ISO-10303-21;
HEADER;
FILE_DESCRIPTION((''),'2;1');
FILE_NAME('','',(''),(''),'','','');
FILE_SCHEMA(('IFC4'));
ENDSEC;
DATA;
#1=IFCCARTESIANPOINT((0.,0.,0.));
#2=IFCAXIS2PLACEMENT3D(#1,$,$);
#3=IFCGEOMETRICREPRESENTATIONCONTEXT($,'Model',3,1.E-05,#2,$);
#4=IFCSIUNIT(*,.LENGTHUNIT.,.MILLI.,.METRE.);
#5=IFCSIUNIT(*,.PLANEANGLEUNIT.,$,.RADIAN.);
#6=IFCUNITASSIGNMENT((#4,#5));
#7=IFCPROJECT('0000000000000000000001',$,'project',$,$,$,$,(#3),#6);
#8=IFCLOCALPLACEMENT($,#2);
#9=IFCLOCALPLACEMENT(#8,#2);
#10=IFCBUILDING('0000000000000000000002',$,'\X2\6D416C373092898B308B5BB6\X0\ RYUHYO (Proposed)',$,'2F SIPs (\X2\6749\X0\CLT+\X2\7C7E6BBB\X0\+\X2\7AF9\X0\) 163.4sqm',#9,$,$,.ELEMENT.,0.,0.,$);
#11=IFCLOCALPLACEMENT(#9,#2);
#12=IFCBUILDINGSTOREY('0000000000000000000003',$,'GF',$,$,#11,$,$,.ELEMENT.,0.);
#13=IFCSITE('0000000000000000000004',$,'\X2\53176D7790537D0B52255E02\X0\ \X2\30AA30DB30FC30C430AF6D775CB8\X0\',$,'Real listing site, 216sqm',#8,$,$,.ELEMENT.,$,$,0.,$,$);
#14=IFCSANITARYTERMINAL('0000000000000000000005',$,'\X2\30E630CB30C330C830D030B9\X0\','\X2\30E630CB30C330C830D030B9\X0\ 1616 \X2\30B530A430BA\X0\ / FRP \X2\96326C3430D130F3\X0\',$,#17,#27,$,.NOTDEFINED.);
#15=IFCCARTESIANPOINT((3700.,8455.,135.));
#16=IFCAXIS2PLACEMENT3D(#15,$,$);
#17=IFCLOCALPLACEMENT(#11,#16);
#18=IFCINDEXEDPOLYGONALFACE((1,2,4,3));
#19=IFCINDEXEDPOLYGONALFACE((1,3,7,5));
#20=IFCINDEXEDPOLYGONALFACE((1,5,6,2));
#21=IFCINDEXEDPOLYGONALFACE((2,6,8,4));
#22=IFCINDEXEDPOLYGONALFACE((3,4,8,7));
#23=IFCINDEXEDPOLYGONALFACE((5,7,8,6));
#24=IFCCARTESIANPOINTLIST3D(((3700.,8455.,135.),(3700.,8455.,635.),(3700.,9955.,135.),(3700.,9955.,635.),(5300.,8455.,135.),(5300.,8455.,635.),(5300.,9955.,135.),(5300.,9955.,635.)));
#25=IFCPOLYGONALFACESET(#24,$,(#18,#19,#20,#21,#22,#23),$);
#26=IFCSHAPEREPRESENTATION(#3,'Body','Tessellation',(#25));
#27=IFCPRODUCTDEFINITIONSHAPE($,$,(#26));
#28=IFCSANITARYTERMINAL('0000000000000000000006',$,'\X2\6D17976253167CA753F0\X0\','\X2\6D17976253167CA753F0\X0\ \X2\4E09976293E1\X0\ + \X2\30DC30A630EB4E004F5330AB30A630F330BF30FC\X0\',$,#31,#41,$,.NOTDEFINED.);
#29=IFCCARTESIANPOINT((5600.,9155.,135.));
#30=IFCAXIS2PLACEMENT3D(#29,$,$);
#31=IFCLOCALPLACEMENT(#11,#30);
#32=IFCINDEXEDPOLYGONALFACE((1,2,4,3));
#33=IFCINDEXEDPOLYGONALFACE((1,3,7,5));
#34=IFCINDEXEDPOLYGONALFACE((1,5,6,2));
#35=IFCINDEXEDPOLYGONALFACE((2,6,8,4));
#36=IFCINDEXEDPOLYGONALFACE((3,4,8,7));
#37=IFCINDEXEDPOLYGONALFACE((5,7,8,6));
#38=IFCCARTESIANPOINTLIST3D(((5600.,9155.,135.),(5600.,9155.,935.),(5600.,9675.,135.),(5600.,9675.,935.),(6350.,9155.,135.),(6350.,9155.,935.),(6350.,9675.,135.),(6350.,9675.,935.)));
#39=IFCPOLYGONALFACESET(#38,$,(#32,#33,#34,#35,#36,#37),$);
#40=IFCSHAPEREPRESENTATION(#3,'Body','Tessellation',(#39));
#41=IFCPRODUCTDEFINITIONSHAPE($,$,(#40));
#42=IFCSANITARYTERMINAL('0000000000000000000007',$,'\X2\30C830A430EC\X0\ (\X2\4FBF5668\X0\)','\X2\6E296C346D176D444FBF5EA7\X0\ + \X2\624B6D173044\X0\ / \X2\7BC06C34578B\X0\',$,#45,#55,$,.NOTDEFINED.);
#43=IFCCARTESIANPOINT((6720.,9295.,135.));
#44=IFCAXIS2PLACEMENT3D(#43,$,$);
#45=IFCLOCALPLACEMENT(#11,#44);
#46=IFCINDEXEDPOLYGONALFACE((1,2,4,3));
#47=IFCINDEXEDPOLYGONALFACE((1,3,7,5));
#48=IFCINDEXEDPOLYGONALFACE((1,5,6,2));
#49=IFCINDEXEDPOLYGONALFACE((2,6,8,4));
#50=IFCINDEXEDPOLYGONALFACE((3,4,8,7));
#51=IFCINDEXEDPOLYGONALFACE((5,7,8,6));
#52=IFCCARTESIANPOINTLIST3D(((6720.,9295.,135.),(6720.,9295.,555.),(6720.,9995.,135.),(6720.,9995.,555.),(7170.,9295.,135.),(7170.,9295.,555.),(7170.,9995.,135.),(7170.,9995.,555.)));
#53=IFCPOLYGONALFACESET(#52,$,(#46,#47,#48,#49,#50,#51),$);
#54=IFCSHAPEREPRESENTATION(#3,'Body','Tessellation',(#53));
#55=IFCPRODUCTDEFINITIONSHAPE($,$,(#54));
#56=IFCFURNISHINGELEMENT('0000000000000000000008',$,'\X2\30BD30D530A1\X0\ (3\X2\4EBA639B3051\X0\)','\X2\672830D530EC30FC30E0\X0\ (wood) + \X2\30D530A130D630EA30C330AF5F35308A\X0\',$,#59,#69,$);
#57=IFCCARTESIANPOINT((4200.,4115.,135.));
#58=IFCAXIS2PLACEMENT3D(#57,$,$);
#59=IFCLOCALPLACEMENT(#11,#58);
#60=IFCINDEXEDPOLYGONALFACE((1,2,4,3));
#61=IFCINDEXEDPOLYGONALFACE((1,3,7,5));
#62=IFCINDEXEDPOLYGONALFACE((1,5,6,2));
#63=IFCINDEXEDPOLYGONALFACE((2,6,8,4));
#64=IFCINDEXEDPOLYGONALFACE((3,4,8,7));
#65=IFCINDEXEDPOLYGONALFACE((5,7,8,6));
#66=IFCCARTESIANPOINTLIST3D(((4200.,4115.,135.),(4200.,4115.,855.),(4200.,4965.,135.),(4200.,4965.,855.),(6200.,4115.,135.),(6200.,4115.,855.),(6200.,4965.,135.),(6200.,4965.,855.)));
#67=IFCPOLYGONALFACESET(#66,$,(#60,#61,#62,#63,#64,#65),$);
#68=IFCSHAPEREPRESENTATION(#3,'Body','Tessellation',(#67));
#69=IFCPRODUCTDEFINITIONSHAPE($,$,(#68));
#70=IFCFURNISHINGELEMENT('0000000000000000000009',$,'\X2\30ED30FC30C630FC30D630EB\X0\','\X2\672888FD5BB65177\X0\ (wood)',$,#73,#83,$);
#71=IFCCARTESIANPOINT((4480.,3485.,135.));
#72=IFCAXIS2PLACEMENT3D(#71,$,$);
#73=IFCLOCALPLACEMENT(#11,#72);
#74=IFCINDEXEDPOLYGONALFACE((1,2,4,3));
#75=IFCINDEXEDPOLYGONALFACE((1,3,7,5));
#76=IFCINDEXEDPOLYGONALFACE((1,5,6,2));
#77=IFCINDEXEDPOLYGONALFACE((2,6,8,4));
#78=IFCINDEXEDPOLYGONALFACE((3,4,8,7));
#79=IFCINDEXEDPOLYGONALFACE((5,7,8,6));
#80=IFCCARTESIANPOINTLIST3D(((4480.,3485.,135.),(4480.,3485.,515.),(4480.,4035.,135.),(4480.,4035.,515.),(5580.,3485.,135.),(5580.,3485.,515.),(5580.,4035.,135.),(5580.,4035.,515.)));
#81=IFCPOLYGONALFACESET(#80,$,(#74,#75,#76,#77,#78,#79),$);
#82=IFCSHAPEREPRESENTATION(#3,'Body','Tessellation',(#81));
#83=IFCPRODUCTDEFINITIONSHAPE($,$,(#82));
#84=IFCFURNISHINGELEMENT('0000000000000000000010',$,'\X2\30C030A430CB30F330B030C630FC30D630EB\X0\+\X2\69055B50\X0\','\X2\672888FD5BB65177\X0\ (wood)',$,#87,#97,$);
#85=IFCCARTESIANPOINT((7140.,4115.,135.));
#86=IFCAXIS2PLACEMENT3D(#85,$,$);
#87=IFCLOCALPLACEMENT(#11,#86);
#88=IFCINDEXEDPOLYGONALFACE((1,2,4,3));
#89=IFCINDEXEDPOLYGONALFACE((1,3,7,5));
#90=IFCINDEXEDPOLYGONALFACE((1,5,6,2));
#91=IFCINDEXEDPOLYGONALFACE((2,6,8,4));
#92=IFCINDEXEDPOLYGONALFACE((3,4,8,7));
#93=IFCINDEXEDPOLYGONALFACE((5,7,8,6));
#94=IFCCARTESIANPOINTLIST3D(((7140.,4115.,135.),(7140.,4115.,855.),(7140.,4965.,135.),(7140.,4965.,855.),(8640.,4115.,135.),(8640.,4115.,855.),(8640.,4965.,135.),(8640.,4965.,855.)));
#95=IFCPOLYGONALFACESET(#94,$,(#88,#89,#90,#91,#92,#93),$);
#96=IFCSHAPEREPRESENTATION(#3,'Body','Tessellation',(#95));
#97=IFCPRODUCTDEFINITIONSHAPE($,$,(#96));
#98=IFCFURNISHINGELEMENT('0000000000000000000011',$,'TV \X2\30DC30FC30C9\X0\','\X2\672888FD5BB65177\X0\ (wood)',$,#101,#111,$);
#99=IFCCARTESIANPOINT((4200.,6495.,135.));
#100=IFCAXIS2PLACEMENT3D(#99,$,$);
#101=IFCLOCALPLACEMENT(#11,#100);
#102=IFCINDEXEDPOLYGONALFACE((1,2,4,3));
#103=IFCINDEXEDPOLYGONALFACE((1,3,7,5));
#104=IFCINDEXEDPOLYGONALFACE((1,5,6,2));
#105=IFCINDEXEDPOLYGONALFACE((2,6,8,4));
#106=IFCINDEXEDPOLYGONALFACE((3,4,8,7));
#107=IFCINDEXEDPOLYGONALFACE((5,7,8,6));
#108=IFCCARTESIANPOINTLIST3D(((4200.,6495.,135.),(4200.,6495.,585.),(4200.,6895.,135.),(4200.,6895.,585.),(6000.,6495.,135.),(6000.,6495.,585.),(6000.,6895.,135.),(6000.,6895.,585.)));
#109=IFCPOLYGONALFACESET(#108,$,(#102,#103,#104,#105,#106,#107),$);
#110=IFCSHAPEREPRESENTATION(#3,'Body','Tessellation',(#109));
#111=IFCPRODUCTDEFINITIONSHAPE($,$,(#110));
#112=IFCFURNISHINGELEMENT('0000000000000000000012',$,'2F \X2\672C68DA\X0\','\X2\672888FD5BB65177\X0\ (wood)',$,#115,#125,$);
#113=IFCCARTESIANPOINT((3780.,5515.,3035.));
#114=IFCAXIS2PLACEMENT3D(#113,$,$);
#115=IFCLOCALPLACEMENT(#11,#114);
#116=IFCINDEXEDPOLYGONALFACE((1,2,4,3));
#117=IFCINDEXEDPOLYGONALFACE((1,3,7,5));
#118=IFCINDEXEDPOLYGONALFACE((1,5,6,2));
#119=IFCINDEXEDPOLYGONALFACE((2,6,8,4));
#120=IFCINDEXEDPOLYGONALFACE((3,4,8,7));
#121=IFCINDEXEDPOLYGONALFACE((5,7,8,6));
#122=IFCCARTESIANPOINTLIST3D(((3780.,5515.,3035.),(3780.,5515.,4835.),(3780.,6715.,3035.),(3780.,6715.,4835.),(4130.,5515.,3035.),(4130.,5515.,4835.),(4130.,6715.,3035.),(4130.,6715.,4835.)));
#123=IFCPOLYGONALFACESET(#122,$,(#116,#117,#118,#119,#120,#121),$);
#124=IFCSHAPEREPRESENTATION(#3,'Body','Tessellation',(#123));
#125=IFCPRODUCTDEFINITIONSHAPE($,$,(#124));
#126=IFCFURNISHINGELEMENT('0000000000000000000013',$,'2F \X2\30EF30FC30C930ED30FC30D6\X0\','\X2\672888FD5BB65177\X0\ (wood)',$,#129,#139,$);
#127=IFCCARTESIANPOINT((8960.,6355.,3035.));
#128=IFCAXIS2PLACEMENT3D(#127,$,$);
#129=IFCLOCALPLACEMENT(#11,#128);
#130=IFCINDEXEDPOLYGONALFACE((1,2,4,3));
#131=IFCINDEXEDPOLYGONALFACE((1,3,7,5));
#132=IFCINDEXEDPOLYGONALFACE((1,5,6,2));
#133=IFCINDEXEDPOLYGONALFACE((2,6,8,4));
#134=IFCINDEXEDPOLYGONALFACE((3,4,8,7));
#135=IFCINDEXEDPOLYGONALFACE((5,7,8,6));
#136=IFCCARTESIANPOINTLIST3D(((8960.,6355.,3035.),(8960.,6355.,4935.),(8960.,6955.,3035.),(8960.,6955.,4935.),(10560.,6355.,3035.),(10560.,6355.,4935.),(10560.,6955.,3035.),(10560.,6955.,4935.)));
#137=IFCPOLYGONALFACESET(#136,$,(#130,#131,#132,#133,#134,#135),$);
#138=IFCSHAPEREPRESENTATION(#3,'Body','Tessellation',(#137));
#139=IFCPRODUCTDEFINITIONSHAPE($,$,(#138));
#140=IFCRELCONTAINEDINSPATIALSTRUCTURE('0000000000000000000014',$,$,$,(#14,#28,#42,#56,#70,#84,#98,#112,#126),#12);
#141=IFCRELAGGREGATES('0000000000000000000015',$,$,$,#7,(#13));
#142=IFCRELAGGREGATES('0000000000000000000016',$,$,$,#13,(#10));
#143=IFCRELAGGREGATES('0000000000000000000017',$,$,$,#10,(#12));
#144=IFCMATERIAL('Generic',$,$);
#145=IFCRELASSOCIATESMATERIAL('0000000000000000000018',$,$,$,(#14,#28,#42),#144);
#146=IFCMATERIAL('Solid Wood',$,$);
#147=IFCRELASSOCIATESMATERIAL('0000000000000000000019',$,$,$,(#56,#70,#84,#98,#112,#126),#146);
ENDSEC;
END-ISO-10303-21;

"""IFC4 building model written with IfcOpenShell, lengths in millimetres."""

from ifc_helpers import new_model, si_unit, frame, frame_2d, origin, place, context, project, spatial, rectangle, extrude, material, element, save


model = new_model("IFC4")

# Units and contexts
model_context = context("Model", 3, precision=1e-05, world=origin())
ifc_project = project(units=[si_unit("LENGTHUNIT", "METRE", prefix="MILLI"), si_unit("PLANEANGLEUNIT", "RADIAN")], contexts=[model_context])

# Site, building, storey
site_placement = place(None, origin())
site = spatial("IfcSite", under=ifc_project, at=site_placement, Name="北海道紋別市 オホーツク海岸", ObjectType="Real listing site, 216sqm", CompositionType="ELEMENT", RefElevation=0.0)
building_placement = place(site_placement, origin())
building = spatial("IfcBuilding", under=site, at=building_placement, Name="流氷を見る家 RYUHYO (Proposed)", ObjectType="2F SIPs (杉CLT+籾殻+竹) 163.4sqm", CompositionType="ELEMENT", ElevationOfRefHeight=0.0, ElevationOfTerrain=0.0)
storey_placement = place(building_placement, origin())
storey = spatial("IfcBuildingStorey", under=building, at=storey_placement, Name="GF", CompositionType="ELEMENT", Elevation=0.0)

# Shared definitions
ifc_material_1 = material(Name="Generic")

# Shared definitions
ifc_material_2 = material(Name="Solid Wood")

# Sanitary terminals
sanitary_terminal_1_placement = place(storey_placement, frame((3700.0, 8455.0, 135.0)))
element("IfcSanitaryTerminal", 1, at=sanitary_terminal_1_placement, inside=storey, material=ifc_material_1, Name="ユニットバス", Description="ユニットバス 1616 サイズ / FRP 防水パン", PredefinedType="NOTDEFINED", context=model_context, shape_type="SweptSolid", body=[
    extrude(rectangle(XDim=1600.0, YDim=1500.0, at=frame_2d((800.0, 750.0))), frame((3700.0, 8455.0, 135.0)), (0.0, 0.0, 1.0), 500.0),
])
sanitary_terminal_2_placement = place(storey_placement, frame((5600.0, 9155.0, 135.0)))
element("IfcSanitaryTerminal", 2, at=sanitary_terminal_2_placement, inside=storey, material=ifc_material_1, Name="洗面化粧台", Description="洗面化粧台 三面鏡 + ボウル一体カウンター", PredefinedType="NOTDEFINED", context=model_context, shape_type="SweptSolid", body=[
    extrude(rectangle(XDim=750.0, YDim=520.0, at=frame_2d((375.0, 260.0))), frame((5600.0, 9155.0, 135.0)), (0.0, 0.0, 1.0), 800.0),
])
sanitary_terminal_3_placement = place(storey_placement, frame((6720.0, 9295.0, 135.0)))
element("IfcSanitaryTerminal", 3, at=sanitary_terminal_3_placement, inside=storey, material=ifc_material_1, Name="トイレ (便器)", Description="温水洗浄便座 + 手洗い / 節水型", PredefinedType="NOTDEFINED", context=model_context, shape_type="SweptSolid", body=[
    extrude(rectangle(XDim=450.0, YDim=700.0, at=frame_2d((225.0, 350.0))), frame((6720.0, 9295.0, 135.0)), (0.0, 0.0, 1.0), 420.0),
])

# Furnishing elements
furnishing_1_placement = place(storey_placement, frame((4200.0, 4115.0, 135.0)))
element("IfcFurnishingElement", 4, at=furnishing_1_placement, inside=storey, material=ifc_material_2, Name="ソファ (3人掛け)", Description="木フレーム (wood) + ファブリック張り", context=model_context, shape_type="SweptSolid", body=[
    extrude(rectangle(XDim=2000.0, YDim=850.0, at=frame_2d((1000.0, 425.0))), frame((4200.0, 4115.0, 135.0)), (0.0, 0.0, 1.0), 720.0),
])
furnishing_2_placement = place(storey_placement, frame((4480.0, 3485.0, 135.0)))
element("IfcFurnishingElement", 5, at=furnishing_2_placement, inside=storey, material=ifc_material_2, Name="ローテーブル", Description="木製家具 (wood)", context=model_context, shape_type="SweptSolid", body=[
    extrude(rectangle(XDim=1100.0, YDim=550.0, at=frame_2d((550.0, 275.0))), frame((4480.0, 3485.0, 135.0)), (0.0, 0.0, 1.0), 380.0),
])
furnishing_3_placement = place(storey_placement, frame((7140.0, 4115.0, 135.0)))
element("IfcFurnishingElement", 6, at=furnishing_3_placement, inside=storey, material=ifc_material_2, Name="ダイニングテーブル+椅子", Description="木製家具 (wood)", context=model_context, shape_type="SweptSolid", body=[
    extrude(rectangle(XDim=1500.0, YDim=850.0, at=frame_2d((750.0, 425.0))), frame((7140.0, 4115.0, 135.0)), (0.0, 0.0, 1.0), 720.0),
])
furnishing_4_placement = place(storey_placement, frame((4200.0, 6495.0, 135.0)))
element("IfcFurnishingElement", 7, at=furnishing_4_placement, inside=storey, material=ifc_material_2, Name="TV ボード", Description="木製家具 (wood)", context=model_context, shape_type="SweptSolid", body=[
    extrude(rectangle(XDim=1800.0, YDim=400.0, at=frame_2d((900.0, 200.0))), frame((4200.0, 6495.0, 135.0)), (0.0, 0.0, 1.0), 450.0),
])
furnishing_5_placement = place(storey_placement, frame((3780.0, 5515.0, 3035.0)))
element("IfcFurnishingElement", 8, at=furnishing_5_placement, inside=storey, material=ifc_material_2, Name="2F 本棚", Description="木製家具 (wood)", context=model_context, shape_type="SweptSolid", body=[
    extrude(rectangle(XDim=350.0, YDim=1200.0, at=frame_2d((175.0, 600.0))), frame((3780.0, 5515.0, 3035.0)), (0.0, 0.0, 1.0), 1800.0),
])
furnishing_6_placement = place(storey_placement, frame((8960.0, 6355.0, 3035.0)))
element("IfcFurnishingElement", 9, at=furnishing_6_placement, inside=storey, material=ifc_material_2, Name="2F ワードローブ", Description="木製家具 (wood)", context=model_context, shape_type="SweptSolid", body=[
    extrude(rectangle(XDim=1600.0, YDim=600.0, at=frame_2d((800.0, 300.0))), frame((8960.0, 6355.0, 3035.0)), (0.0, 0.0, 1.0), 1900.0),
])

save(model, "model.ifc")
